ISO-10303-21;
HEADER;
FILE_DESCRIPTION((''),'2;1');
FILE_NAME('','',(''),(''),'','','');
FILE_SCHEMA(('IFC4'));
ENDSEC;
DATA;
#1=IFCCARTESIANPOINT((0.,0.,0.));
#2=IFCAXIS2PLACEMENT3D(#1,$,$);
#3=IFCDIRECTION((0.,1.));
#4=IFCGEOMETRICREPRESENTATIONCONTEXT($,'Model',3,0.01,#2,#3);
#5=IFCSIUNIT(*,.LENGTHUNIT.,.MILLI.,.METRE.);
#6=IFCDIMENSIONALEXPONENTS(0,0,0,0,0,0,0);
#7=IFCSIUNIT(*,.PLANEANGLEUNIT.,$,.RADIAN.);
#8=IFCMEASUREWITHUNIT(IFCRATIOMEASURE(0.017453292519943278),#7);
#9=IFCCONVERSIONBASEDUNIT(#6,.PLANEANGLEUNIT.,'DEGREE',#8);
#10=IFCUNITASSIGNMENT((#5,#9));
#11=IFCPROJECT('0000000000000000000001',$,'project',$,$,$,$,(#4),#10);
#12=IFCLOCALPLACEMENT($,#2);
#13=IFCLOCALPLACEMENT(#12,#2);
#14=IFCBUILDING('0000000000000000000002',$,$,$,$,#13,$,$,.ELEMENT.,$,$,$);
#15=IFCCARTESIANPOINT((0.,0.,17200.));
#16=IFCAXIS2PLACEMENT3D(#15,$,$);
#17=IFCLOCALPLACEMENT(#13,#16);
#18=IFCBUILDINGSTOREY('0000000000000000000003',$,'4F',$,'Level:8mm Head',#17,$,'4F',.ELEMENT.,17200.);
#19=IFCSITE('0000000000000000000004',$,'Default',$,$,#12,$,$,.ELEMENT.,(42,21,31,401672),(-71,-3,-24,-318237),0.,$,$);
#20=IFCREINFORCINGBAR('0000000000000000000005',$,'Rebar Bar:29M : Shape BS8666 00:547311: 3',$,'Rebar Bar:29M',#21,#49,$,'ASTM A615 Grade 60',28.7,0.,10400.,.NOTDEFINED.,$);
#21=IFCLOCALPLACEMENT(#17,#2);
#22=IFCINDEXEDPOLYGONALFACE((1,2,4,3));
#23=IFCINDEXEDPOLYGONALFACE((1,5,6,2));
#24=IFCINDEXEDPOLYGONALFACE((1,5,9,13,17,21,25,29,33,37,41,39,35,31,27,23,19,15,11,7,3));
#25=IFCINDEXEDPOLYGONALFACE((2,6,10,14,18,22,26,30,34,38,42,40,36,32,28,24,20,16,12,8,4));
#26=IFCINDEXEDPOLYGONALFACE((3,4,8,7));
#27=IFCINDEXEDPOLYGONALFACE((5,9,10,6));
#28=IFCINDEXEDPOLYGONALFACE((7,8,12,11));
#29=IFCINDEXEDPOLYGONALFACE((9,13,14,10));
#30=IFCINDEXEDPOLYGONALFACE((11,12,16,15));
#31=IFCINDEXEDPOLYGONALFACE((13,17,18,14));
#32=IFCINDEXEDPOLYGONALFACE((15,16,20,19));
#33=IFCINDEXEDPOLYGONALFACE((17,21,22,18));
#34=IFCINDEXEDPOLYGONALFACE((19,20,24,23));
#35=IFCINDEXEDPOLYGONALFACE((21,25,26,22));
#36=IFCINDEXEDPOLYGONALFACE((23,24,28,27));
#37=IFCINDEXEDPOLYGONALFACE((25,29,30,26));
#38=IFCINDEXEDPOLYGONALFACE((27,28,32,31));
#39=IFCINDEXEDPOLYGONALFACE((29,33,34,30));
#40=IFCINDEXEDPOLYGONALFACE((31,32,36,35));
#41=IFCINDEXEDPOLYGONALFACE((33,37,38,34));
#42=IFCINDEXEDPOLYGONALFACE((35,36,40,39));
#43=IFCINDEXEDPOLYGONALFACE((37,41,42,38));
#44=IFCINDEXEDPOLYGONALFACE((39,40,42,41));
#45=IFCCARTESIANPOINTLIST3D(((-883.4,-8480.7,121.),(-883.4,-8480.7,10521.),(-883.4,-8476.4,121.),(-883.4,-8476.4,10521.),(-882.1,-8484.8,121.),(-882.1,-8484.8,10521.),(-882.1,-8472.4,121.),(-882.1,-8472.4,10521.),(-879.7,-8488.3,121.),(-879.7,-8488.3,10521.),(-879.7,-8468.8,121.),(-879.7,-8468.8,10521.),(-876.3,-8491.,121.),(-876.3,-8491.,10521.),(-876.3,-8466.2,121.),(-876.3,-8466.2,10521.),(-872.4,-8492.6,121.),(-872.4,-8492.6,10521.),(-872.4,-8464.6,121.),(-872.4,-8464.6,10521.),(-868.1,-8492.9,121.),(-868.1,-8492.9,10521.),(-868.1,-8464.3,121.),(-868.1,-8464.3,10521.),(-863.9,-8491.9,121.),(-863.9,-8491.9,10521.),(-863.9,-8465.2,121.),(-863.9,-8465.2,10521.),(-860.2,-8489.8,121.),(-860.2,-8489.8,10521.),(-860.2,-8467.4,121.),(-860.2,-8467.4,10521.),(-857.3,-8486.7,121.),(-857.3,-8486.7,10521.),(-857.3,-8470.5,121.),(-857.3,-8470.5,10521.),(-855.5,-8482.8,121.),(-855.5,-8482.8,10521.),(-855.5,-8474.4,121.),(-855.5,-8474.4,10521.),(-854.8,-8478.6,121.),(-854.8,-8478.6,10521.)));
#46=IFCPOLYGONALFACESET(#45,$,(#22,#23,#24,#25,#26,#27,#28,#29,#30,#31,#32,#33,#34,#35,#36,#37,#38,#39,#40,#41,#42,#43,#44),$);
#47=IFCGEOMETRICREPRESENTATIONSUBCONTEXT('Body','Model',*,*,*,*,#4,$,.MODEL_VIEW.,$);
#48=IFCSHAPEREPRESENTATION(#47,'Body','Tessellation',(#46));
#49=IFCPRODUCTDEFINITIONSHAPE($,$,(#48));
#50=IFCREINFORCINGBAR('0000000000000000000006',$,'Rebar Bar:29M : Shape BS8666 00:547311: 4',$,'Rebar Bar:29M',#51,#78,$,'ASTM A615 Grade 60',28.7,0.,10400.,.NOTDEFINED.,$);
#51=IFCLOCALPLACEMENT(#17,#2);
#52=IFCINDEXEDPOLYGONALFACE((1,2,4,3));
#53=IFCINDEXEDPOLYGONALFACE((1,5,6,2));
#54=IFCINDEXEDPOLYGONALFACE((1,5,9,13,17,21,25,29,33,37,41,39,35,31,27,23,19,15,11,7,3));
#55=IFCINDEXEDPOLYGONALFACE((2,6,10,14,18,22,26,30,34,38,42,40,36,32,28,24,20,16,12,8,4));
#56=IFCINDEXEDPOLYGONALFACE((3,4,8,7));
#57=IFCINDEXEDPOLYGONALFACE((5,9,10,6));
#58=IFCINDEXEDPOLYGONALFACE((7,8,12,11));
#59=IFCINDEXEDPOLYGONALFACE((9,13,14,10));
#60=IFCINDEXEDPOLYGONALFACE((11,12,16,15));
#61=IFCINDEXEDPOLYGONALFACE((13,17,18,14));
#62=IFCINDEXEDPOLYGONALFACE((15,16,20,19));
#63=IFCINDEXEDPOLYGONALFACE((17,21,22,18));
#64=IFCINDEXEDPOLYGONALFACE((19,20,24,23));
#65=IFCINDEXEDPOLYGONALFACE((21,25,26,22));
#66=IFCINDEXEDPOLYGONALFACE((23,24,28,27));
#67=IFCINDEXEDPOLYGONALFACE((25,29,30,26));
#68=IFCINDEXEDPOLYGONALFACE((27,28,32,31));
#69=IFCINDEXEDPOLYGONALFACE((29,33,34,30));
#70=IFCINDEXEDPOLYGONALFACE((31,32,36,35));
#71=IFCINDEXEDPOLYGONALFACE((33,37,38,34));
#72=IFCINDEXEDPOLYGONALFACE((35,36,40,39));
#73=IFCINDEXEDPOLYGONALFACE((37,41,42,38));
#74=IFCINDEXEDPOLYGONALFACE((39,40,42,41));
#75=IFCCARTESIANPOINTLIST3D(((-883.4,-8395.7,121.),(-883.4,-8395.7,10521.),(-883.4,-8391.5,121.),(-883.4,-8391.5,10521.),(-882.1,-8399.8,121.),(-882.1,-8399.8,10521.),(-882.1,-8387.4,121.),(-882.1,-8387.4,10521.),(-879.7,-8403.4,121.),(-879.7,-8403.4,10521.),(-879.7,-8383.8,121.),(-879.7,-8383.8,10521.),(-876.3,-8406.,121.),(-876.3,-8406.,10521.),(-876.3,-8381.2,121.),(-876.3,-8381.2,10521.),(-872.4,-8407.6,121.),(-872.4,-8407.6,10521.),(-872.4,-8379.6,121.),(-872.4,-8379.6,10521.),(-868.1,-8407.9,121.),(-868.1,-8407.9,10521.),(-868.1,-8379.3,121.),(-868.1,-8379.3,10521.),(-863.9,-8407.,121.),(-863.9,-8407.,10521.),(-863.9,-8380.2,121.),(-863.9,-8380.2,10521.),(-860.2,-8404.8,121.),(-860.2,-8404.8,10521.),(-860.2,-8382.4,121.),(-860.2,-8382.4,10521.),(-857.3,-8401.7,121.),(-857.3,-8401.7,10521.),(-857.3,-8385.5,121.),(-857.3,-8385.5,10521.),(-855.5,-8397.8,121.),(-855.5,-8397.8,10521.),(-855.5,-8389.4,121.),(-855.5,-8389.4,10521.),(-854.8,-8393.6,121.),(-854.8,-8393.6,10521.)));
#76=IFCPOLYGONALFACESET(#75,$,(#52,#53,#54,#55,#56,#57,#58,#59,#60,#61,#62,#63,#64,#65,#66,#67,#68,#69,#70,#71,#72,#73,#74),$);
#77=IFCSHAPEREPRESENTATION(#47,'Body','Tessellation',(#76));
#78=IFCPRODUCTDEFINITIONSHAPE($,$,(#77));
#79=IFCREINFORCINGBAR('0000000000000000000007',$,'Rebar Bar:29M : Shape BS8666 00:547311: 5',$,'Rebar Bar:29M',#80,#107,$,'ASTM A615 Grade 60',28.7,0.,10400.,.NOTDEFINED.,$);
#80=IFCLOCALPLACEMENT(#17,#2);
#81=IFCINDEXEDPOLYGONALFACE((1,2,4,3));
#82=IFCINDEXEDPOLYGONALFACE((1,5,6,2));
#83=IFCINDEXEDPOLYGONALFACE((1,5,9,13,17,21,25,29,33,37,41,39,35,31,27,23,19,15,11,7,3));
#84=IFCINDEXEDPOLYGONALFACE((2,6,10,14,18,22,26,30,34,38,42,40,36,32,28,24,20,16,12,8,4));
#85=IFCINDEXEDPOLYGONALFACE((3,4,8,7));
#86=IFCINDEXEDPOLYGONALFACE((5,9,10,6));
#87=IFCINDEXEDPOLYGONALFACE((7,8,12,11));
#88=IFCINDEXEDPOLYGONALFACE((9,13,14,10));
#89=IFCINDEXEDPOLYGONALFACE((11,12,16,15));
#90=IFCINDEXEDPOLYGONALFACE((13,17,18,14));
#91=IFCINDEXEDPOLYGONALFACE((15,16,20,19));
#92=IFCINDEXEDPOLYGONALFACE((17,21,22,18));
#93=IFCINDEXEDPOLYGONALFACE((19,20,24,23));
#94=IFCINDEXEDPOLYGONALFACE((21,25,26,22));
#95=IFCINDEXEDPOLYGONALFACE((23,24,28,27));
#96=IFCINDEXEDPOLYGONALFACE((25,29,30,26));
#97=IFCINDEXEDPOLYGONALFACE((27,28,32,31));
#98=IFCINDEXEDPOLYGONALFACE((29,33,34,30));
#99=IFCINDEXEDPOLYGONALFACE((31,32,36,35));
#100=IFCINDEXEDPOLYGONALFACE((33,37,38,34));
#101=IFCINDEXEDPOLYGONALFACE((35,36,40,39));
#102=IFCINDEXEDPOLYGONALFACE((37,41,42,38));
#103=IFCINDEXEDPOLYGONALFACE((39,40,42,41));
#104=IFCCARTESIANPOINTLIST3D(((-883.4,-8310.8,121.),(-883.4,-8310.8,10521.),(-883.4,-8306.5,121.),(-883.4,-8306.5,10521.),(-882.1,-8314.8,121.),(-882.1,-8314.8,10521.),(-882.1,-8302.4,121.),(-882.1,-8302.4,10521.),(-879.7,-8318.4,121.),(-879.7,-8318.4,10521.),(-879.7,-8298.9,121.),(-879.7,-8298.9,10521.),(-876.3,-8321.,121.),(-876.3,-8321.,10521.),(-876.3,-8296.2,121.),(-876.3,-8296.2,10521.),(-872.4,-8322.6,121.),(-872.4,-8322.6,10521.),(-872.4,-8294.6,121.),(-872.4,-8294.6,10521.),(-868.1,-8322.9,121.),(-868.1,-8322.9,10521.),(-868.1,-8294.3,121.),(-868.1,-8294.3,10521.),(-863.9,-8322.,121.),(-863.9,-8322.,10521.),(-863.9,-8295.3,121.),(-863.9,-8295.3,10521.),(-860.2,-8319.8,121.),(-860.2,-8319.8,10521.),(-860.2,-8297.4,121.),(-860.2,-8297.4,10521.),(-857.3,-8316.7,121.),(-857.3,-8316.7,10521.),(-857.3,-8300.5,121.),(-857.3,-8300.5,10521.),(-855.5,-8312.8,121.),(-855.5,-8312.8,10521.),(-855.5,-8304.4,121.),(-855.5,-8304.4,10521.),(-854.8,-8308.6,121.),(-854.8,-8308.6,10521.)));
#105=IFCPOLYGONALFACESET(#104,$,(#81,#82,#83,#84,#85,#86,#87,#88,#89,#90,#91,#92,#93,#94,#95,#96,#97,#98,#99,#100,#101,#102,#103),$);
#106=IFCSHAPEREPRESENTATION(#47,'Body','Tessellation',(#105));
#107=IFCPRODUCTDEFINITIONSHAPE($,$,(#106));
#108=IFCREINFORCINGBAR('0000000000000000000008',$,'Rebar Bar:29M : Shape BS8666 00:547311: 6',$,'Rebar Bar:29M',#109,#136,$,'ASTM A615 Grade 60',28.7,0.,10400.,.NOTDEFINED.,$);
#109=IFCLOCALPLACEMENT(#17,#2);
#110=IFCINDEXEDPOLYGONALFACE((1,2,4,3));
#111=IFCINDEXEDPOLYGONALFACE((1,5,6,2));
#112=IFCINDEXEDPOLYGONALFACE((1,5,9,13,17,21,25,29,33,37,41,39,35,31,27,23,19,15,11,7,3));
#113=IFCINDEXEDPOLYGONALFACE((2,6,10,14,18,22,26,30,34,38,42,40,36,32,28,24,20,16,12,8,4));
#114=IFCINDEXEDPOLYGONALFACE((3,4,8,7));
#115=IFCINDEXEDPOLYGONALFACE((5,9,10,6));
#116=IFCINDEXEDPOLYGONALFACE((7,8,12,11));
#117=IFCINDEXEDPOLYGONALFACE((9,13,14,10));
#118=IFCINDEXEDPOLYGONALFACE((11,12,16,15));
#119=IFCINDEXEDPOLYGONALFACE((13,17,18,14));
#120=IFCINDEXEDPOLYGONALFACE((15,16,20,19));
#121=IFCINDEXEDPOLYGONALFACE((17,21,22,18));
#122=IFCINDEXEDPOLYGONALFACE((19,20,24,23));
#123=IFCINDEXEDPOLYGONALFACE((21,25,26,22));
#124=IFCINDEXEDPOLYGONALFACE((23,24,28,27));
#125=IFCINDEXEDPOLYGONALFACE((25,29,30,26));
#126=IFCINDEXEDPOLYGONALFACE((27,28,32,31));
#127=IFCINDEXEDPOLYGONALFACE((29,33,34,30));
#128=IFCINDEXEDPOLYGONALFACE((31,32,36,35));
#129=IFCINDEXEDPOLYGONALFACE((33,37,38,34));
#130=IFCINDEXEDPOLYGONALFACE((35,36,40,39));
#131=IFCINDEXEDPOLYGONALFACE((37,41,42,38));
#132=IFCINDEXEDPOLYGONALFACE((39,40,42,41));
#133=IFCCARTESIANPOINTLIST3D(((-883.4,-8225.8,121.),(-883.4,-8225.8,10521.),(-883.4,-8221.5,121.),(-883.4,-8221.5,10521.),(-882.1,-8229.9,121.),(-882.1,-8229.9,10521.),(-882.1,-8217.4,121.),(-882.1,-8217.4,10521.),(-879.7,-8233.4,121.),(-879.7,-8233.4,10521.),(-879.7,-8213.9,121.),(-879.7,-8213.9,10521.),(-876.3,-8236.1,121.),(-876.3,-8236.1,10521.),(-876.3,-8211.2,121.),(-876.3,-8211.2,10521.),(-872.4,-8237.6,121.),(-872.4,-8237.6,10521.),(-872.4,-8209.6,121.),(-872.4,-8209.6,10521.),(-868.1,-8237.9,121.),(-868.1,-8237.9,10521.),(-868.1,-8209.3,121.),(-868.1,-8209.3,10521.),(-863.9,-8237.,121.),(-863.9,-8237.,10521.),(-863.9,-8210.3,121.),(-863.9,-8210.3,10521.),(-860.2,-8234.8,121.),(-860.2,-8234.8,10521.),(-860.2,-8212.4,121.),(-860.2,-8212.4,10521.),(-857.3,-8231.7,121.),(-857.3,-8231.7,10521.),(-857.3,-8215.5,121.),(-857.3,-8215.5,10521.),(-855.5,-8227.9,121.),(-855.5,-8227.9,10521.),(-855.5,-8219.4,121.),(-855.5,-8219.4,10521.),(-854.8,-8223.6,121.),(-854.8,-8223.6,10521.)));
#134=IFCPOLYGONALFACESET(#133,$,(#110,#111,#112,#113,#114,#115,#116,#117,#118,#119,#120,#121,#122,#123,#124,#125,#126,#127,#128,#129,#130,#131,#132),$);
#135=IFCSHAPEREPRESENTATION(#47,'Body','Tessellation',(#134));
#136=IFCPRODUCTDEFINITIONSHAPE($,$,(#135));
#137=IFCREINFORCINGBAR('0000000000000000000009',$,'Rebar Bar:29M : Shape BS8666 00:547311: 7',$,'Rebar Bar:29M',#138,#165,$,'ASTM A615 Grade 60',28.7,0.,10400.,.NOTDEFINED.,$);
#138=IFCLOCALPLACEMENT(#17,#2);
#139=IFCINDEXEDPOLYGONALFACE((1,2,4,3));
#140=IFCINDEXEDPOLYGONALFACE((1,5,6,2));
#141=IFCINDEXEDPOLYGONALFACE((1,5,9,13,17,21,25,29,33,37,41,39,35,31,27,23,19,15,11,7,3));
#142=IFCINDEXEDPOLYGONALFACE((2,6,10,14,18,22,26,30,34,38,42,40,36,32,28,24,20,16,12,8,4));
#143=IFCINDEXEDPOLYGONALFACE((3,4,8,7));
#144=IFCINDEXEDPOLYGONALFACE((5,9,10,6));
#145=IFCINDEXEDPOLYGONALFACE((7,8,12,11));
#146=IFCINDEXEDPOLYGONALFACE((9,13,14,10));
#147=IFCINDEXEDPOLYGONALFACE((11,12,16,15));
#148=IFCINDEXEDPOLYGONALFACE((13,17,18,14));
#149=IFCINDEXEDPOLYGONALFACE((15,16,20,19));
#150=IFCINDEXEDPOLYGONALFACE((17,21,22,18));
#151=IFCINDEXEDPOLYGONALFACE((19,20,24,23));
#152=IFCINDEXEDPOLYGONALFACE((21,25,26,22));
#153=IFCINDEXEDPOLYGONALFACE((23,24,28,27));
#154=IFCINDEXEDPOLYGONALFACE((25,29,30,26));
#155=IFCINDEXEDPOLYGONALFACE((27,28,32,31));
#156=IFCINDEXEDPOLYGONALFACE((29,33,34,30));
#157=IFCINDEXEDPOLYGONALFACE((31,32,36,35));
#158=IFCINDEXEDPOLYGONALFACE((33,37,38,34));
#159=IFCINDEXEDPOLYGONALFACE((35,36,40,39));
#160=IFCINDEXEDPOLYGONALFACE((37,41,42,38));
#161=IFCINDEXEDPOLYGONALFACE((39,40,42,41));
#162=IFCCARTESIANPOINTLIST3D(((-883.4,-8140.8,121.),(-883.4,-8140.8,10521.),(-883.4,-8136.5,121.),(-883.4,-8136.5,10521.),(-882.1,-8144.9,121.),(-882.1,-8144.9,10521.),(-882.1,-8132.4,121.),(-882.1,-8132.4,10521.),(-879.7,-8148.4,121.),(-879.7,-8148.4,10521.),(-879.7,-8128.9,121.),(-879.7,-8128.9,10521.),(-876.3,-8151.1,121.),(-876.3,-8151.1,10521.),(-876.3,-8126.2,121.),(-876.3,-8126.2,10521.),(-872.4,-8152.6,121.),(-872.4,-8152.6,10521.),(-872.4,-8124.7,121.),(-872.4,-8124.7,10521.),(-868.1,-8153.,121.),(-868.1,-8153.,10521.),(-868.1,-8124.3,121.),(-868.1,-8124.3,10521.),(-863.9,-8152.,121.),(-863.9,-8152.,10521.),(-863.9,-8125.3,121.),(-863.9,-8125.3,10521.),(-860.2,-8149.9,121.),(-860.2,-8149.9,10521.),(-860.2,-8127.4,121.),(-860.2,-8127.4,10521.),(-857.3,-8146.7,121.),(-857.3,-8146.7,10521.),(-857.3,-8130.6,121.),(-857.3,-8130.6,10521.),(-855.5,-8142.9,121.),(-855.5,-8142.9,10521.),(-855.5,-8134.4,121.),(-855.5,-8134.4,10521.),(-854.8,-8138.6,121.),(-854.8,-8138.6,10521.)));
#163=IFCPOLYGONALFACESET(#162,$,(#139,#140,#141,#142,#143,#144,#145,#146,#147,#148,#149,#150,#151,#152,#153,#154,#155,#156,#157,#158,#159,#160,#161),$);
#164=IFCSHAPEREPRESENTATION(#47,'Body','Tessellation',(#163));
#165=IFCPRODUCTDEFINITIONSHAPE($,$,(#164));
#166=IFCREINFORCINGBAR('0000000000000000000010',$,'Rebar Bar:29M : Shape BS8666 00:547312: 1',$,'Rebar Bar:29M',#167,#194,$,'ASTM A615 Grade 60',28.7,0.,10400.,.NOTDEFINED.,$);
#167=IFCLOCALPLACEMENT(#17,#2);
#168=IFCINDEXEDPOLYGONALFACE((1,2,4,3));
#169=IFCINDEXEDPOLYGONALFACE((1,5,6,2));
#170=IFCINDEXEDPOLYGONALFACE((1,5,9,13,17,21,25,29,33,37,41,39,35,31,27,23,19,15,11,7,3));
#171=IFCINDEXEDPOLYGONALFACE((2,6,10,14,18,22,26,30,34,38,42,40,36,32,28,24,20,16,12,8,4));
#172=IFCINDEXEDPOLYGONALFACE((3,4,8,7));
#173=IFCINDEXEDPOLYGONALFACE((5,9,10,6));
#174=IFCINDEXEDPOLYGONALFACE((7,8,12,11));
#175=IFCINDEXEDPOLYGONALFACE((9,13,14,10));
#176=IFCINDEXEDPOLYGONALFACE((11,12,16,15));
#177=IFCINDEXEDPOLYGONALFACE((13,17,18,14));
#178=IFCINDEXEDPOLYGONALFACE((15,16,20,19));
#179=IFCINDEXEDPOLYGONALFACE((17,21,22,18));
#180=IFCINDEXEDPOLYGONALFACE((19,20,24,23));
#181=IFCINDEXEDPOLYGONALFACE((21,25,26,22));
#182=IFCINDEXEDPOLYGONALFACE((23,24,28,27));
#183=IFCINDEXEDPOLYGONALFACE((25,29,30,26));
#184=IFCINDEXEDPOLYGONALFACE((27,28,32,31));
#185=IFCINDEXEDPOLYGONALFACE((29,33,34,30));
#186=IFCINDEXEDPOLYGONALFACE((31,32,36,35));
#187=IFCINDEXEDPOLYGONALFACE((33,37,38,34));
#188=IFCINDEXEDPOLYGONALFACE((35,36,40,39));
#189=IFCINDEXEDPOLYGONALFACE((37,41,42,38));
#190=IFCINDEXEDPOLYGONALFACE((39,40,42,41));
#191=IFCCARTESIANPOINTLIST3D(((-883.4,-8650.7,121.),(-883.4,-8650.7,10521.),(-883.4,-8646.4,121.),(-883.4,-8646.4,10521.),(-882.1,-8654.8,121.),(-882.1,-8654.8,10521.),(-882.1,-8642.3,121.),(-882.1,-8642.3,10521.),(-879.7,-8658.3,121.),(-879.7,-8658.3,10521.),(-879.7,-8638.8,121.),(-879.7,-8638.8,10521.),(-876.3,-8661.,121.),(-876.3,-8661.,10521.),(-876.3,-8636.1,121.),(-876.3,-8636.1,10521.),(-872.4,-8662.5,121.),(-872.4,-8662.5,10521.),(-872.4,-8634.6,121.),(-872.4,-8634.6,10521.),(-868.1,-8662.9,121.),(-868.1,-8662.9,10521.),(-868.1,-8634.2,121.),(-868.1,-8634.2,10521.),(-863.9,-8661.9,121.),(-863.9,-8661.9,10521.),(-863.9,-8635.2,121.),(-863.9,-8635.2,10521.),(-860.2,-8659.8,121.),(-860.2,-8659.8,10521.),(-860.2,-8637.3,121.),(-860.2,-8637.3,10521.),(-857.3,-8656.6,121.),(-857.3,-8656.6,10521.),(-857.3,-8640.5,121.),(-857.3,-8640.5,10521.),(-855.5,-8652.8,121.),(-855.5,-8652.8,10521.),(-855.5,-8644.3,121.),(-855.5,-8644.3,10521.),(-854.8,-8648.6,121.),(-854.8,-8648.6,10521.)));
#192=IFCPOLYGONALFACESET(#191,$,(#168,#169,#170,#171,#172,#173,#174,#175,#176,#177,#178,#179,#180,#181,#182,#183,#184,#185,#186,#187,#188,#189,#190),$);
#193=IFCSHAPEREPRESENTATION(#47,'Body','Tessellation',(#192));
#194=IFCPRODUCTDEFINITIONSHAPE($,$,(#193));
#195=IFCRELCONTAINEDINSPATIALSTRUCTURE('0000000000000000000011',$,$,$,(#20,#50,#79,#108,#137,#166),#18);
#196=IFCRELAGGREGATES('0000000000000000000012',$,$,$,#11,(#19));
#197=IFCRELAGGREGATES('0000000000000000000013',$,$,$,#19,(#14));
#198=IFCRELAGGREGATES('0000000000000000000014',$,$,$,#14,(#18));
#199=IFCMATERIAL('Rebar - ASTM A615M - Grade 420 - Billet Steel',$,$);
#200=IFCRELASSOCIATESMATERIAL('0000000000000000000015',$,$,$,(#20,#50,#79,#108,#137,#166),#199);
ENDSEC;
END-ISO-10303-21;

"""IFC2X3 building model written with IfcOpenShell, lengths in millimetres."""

from ifc_helpers import new_model, entity, si_unit, converted_unit, direction, frame, origin, place, context, subcontext, project, spatial, material, element, save


model = new_model("IFC2X3")

# Units and contexts
model_context = context("Model", 3, precision=0.01, world=origin(), true_north=direction((0.0, 1.0)))
body_context = subcontext(model_context, "Body", "Model", "MODEL_VIEW")
ifc_project = project(units=[si_unit("LENGTHUNIT", "METRE", prefix="MILLI"), converted_unit("PLANEANGLEUNIT", "DEGREE", entity("IfcRatioMeasure", 0.017453292519943278), si_unit("PLANEANGLEUNIT", "RADIAN"), dimensions=[0, 0, 0, 0, 0, 0, 0])], contexts=[model_context])

# Site, building, storey
site_placement = place(None, origin())
site = spatial("IfcSite", under=ifc_project, at=site_placement, Name="Default", CompositionType="ELEMENT", RefLatitude=(42, 21, 31, 401672), RefLongitude=(-71, -3, -24, -318237), RefElevation=0.0)
building_placement = place(site_placement, origin())
building = spatial("IfcBuilding", under=site, at=building_placement, CompositionType="ELEMENT")
storey_placement = place(building_placement, frame((0.0, 0.0, 17200.0)))
storey = spatial("IfcBuildingStorey", under=building, at=storey_placement, Name="4F", ObjectType="Level:8mm Head", LongName="4F", CompositionType="ELEMENT", Elevation=17200.0)

# Reinforcing bars
ifc_material_1 = material(Name="Rebar - ASTM A615M - Grade 420 - Billet Steel")
reinforcing_bar_1_placement = place(storey_placement, origin())
element("IfcReinforcingBar", 1, at=reinforcing_bar_1_placement, inside=storey, material=ifc_material_1, Name="Rebar Bar:29M : Shape BS8666 00:547311: 3", SteelGrade="ASTM A615 Grade 60", ObjectType="Rebar Bar:29M", BarLength=10400.0, BarRole="NOTDEFINED", CrossSectionArea=0.0, NominalDiameter=28.7, context=body_context, shape_type="AdvancedSweptSolid", body=[
    entity("IfcSweptDiskSolid", entity("IfcCompositeCurve", [entity("IfcCompositeCurveSegment", "CONTINUOUS", True, entity("IfcPolyline", [entity("IfcCartesianPoint", [-869.2, -8478.6, 121.0]), entity("IfcCartesianPoint", [-869.2, -8478.6, 10521.0])]))], False), 14.3, None, 0.0, 1.0),
])
reinforcing_bar_2_placement = place(storey_placement, origin())
element("IfcReinforcingBar", 2, at=reinforcing_bar_2_placement, inside=storey, material=ifc_material_1, Name="Rebar Bar:29M : Shape BS8666 00:547311: 4", SteelGrade="ASTM A615 Grade 60", ObjectType="Rebar Bar:29M", BarLength=10400.0, BarRole="NOTDEFINED", CrossSectionArea=0.0, NominalDiameter=28.7, context=body_context, shape_type="AdvancedSweptSolid", body=[
    entity("IfcSweptDiskSolid", entity("IfcCompositeCurve", [entity("IfcCompositeCurveSegment", "CONTINUOUS", True, entity("IfcPolyline", [entity("IfcCartesianPoint", [-869.2, -8393.6, 121.0]), entity("IfcCartesianPoint", [-869.2, -8393.6, 10521.0])]))], False), 14.3, None, 0.0, 1.0),
])
reinforcing_bar_3_placement = place(storey_placement, origin())
element("IfcReinforcingBar", 3, at=reinforcing_bar_3_placement, inside=storey, material=ifc_material_1, Name="Rebar Bar:29M : Shape BS8666 00:547311: 5", SteelGrade="ASTM A615 Grade 60", ObjectType="Rebar Bar:29M", BarLength=10400.0, BarRole="NOTDEFINED", CrossSectionArea=0.0, NominalDiameter=28.7, context=body_context, shape_type="AdvancedSweptSolid", body=[
    entity("IfcSweptDiskSolid", entity("IfcCompositeCurve", [entity("IfcCompositeCurveSegment", "CONTINUOUS", True, entity("IfcPolyline", [entity("IfcCartesianPoint", [-869.2, -8308.6, 121.0]), entity("IfcCartesianPoint", [-869.2, -8308.6, 10521.0])]))], False), 14.3, None, 0.0, 1.0),
])
reinforcing_bar_4_placement = place(storey_placement, origin())
element("IfcReinforcingBar", 4, at=reinforcing_bar_4_placement, inside=storey, material=ifc_material_1, Name="Rebar Bar:29M : Shape BS8666 00:547311: 6", SteelGrade="ASTM A615 Grade 60", ObjectType="Rebar Bar:29M", BarLength=10400.0, BarRole="NOTDEFINED", CrossSectionArea=0.0, NominalDiameter=28.7, context=body_context, shape_type="AdvancedSweptSolid", body=[
    entity("IfcSweptDiskSolid", entity("IfcCompositeCurve", [entity("IfcCompositeCurveSegment", "CONTINUOUS", True, entity("IfcPolyline", [entity("IfcCartesianPoint", [-869.2, -8223.6, 121.0]), entity("IfcCartesianPoint", [-869.2, -8223.6, 10521.0])]))], False), 14.3, None, 0.0, 1.0),
])
reinforcing_bar_5_placement = place(storey_placement, origin())
element("IfcReinforcingBar", 5, at=reinforcing_bar_5_placement, inside=storey, material=ifc_material_1, Name="Rebar Bar:29M : Shape BS8666 00:547311: 7", SteelGrade="ASTM A615 Grade 60", ObjectType="Rebar Bar:29M", BarLength=10400.0, BarRole="NOTDEFINED", CrossSectionArea=0.0, NominalDiameter=28.7, context=body_context, shape_type="AdvancedSweptSolid", body=[
    entity("IfcSweptDiskSolid", entity("IfcCompositeCurve", [entity("IfcCompositeCurveSegment", "CONTINUOUS", True, entity("IfcPolyline", [entity("IfcCartesianPoint", [-869.2, -8138.6, 121.0]), entity("IfcCartesianPoint", [-869.2, -8138.6, 10521.0])]))], False), 14.3, None, 0.0, 1.0),
])
reinforcing_bar_6_placement = place(storey_placement, origin())
element("IfcReinforcingBar", 6, at=reinforcing_bar_6_placement, inside=storey, material=ifc_material_1, Name="Rebar Bar:29M : Shape BS8666 00:547312: 1", SteelGrade="ASTM A615 Grade 60", ObjectType="Rebar Bar:29M", BarLength=10400.0, BarRole="NOTDEFINED", CrossSectionArea=0.0, NominalDiameter=28.7, context=body_context, shape_type="AdvancedSweptSolid", body=[
    entity("IfcSweptDiskSolid", entity("IfcCompositeCurve", [entity("IfcCompositeCurveSegment", "CONTINUOUS", True, entity("IfcPolyline", [entity("IfcCartesianPoint", [-869.2, -8648.6, 121.0]), entity("IfcCartesianPoint", [-869.2, -8648.6, 10521.0])]))], False), 14.3, None, 0.0, 1.0),
])

save(model, "model.ifc")
